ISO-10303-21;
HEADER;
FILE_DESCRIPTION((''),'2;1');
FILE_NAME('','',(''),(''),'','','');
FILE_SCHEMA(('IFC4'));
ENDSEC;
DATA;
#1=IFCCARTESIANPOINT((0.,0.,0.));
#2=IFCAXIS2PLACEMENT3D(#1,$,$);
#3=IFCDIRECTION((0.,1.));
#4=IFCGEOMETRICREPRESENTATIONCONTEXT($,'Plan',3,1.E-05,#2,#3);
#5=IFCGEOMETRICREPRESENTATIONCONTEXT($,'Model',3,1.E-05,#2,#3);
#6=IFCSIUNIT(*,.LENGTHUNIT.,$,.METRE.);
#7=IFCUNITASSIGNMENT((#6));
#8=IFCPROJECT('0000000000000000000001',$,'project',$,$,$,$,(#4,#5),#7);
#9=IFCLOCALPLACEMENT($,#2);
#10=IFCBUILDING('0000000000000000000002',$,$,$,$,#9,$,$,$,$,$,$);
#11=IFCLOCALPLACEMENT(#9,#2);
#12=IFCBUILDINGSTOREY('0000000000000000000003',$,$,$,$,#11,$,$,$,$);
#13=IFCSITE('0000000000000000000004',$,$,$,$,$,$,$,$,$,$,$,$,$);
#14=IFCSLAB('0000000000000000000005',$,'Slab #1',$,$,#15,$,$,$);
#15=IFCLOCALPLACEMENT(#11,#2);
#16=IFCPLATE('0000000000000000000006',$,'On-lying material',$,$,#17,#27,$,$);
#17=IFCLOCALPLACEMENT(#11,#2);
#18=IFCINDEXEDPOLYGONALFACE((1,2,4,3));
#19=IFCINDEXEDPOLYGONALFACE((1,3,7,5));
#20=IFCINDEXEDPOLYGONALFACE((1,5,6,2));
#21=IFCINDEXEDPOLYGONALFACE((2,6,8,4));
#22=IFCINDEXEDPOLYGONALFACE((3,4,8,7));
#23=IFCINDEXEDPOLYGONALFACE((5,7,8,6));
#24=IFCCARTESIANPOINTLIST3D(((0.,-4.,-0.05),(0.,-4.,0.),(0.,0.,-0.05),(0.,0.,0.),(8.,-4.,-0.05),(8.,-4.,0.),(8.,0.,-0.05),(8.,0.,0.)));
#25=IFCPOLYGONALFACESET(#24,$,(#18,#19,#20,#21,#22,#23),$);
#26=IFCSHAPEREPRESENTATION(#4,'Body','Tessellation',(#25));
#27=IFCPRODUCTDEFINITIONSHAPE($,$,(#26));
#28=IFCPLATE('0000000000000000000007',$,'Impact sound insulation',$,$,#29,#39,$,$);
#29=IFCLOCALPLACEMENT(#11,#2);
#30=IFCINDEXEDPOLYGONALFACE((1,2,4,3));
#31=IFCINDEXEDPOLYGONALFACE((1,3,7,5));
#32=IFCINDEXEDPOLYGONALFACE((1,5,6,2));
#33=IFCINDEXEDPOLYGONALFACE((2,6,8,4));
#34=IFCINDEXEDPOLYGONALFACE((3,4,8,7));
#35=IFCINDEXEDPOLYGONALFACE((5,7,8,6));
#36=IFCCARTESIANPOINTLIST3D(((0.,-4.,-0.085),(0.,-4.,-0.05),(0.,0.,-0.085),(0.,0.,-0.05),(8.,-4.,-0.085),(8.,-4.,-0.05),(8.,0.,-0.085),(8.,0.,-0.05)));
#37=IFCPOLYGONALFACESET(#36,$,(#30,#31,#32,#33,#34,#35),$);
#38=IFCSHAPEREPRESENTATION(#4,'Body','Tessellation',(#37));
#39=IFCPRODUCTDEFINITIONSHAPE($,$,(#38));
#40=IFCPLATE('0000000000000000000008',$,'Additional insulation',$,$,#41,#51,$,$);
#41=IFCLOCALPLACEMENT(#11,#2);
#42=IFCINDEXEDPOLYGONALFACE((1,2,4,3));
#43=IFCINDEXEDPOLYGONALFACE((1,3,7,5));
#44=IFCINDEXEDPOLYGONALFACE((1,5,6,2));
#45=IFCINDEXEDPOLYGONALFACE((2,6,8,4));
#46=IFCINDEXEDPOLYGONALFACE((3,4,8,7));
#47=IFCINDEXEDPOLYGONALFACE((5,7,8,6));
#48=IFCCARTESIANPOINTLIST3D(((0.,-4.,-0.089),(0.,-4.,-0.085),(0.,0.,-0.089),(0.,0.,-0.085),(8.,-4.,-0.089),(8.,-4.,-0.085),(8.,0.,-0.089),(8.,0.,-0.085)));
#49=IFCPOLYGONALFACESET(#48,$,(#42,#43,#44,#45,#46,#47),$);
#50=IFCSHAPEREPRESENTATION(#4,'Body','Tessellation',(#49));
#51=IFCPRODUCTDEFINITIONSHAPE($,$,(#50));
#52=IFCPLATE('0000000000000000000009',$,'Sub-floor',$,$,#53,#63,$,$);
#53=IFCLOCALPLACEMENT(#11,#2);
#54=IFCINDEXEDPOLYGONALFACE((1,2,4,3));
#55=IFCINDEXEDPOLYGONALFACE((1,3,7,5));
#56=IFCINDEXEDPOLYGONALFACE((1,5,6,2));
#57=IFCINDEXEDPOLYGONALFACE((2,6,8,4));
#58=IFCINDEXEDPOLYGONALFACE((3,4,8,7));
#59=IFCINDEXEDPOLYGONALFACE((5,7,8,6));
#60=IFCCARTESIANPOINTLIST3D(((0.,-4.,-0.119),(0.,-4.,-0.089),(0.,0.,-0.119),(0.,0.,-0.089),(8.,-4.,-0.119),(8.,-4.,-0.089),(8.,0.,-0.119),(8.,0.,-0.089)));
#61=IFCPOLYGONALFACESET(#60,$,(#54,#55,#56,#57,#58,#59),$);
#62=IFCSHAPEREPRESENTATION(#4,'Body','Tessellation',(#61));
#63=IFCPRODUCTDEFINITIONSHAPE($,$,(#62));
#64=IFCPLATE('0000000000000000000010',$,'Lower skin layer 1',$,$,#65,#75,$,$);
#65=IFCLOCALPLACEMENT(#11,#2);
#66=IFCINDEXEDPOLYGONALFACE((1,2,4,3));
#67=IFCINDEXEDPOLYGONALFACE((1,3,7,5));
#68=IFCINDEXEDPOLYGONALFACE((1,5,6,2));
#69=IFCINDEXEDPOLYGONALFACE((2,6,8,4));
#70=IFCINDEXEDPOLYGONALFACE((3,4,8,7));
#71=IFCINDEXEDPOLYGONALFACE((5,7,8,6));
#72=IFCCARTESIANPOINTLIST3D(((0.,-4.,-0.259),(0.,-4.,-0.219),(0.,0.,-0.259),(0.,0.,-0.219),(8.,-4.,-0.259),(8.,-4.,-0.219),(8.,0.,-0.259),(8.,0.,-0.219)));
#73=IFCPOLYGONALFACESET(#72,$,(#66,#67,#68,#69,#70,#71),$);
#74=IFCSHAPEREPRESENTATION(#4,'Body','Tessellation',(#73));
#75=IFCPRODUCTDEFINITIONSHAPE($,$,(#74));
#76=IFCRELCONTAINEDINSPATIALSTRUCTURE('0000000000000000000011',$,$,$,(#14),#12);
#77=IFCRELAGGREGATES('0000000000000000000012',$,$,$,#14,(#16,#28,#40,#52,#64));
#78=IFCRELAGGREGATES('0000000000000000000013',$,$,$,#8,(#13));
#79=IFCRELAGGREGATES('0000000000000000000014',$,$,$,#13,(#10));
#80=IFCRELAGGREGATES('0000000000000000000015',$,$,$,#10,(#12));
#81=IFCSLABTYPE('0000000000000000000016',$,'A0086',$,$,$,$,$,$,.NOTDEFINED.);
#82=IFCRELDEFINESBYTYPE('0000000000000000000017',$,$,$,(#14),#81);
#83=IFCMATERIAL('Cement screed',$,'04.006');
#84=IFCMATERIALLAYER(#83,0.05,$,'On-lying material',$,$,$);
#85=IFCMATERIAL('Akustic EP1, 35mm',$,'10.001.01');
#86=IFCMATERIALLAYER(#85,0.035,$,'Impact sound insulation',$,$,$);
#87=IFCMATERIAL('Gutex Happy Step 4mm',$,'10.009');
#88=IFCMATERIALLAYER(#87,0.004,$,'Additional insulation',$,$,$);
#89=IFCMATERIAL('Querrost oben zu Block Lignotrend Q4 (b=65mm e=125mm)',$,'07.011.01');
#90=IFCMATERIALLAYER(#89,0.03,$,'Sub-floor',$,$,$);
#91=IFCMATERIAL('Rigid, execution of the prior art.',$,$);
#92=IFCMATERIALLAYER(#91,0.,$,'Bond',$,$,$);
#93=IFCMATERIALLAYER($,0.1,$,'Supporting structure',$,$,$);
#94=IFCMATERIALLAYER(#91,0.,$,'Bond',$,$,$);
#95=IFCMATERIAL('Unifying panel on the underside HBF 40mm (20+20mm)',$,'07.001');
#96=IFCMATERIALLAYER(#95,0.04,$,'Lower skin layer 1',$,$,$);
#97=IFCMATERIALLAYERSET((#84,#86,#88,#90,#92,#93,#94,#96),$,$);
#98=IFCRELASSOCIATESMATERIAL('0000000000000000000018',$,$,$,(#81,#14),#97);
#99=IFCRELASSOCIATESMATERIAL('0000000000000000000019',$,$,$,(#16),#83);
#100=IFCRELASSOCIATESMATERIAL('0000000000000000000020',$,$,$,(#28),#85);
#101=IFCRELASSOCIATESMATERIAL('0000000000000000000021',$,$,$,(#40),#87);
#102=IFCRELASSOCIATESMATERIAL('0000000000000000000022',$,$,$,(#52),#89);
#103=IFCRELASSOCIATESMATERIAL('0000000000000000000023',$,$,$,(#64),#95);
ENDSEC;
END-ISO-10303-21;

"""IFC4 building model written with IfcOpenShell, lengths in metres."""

from ifc_helpers import new_model, si_unit, direction, frame, frame_2d, origin, origin_with_axes, place, context, project, spatial, rectangle, extrude, material, layer, layer_set, type_object, element, aggregate, save


model = new_model("IFC4")

# Units and contexts
plan_context = context("Plan", 3, precision=1e-05, world=origin(), true_north=direction((0.0, 1.0)))
model_context = context("Model", 3, precision=1e-05, world=origin(), true_north=direction((0.0, 1.0)))
ifc_project = project(units=[si_unit("LENGTHUNIT", "METRE")], contexts=[plan_context, model_context])

# Site, building, storey
site = spatial("IfcSite", under=ifc_project)
building_placement = place(None, origin())
building = spatial("IfcBuilding", under=site, at=building_placement)
storey_placement = place(building_placement, origin())
storey = spatial("IfcBuildingStorey", under=building, at=storey_placement)

# Slab, plates
ifc_material_1 = material(Name="Cement screed", Category="04.006")
ifc_layer_1 = layer(ifc_material_1, 0.05, Name="On-lying material")
ifc_material_2 = material(Name="Akustic EP1, 35mm", Category="10.001.01")
ifc_layer_2 = layer(ifc_material_2, 0.035, Name="Impact sound insulation")
ifc_material_3 = material(Name="Gutex Happy Step 4mm", Category="10.009")
ifc_layer_3 = layer(ifc_material_3, 0.004, Name="Additional insulation")
ifc_material_4 = material(Name="Querrost oben zu Block Lignotrend Q4 (b=65mm e=125mm)", Category="07.011.01")
ifc_layer_4 = layer(ifc_material_4, 0.03, Name="Sub-floor")
ifc_material_5 = material(Name="Rigid, execution of the prior art.")
ifc_layer_5 = layer(ifc_material_5, 0.0, Name="Bond")
ifc_layer_6 = layer(None, 0.1, Name="Supporting structure")
ifc_layer_7 = layer(ifc_material_5, 0.0, Name="Bond")
ifc_material_6 = material(Name="Unifying panel on the underside HBF 40mm (20+20mm)", Category="07.001")
ifc_layer_8 = layer(ifc_material_6, 0.04, Name="Lower skin layer 1")
ifc_layer_set = layer_set([ifc_layer_1, ifc_layer_2, ifc_layer_3, ifc_layer_4, ifc_layer_5, ifc_layer_6, ifc_layer_7, ifc_layer_8])
slab_type = type_object("IfcSlabType", Name="A0086", PredefinedType="NOTDEFINED", material=ifc_layer_set)
slab_placement = place(None, frame((0.0, 0.0, 0.0), z_axis=(0.0, 0.0, -1.0), x_axis=(1.0, 0.0, 0.0)))
slab = element("IfcSlab", 1, at=slab_placement, inside=storey, type_object=slab_type, material=ifc_layer_set, Name="Slab #1")
plate_1_placement = place(slab_placement, origin())
plate_1 = element("IfcPlate", 2, at=plate_1_placement, material=ifc_material_1, Name="On-lying material", context=plan_context, shape_type="SweptSolid", body=[
    extrude(rectangle(XDim=8.0, YDim=4.0, at=frame_2d((4.0, 2.0), x_axis=(1.0, 0.0))), origin_with_axes(), (0.0, 0.0, 1.0), 0.05),
])
plate_2_placement = place(slab_placement, origin())
plate_2 = element("IfcPlate", 3, at=plate_2_placement, material=ifc_material_2, Name="Impact sound insulation", context=plan_context, shape_type="SweptSolid", body=[
    extrude(rectangle(XDim=8.0, YDim=4.0, at=frame_2d((4.0, 2.0), x_axis=(1.0, 0.0))), frame((0.0, 0.0, 0.05), z_axis=(0.0, 0.0, 1.0), x_axis=(1.0, 0.0, 0.0)), (0.0, 0.0, 1.0), 0.035),
])
plate_3_placement = place(slab_placement, origin())
plate_3 = element("IfcPlate", 4, at=plate_3_placement, material=ifc_material_3, Name="Additional insulation", context=plan_context, shape_type="SweptSolid", body=[
    extrude(rectangle(XDim=8.0, YDim=4.0, at=frame_2d((4.0, 2.0), x_axis=(1.0, 0.0))), frame((0.0, 0.0, 0.085), z_axis=(0.0, 0.0, 1.0), x_axis=(1.0, 0.0, 0.0)), (0.0, 0.0, 1.0), 0.004),
])
plate_4_placement = place(slab_placement, origin())
plate_4 = element("IfcPlate", 5, at=plate_4_placement, material=ifc_material_4, Name="Sub-floor", context=plan_context, shape_type="SweptSolid", body=[
    extrude(rectangle(XDim=8.0, YDim=4.0, at=frame_2d((4.0, 2.0), x_axis=(1.0, 0.0))), frame((0.0, 0.0, 0.089), z_axis=(0.0, 0.0, 1.0), x_axis=(1.0, 0.0, 0.0)), (0.0, 0.0, 1.0), 0.03),
])
plate_5_placement = place(slab_placement, origin())
plate_5 = element("IfcPlate", 6, at=plate_5_placement, material=ifc_material_6, Name="Lower skin layer 1", context=plan_context, shape_type="SweptSolid", body=[
    extrude(rectangle(XDim=8.0, YDim=4.0, at=frame_2d((4.0, 2.0), x_axis=(1.0, 0.0))), frame((0.0, 0.0, 0.219), z_axis=(0.0, 0.0, 1.0), x_axis=(1.0, 0.0, 0.0)), (0.0, 0.0, 1.0), 0.04),
])
aggregate(slab, [plate_1, plate_2, plate_3, plate_4, plate_5])

save(model, "model.ifc")
